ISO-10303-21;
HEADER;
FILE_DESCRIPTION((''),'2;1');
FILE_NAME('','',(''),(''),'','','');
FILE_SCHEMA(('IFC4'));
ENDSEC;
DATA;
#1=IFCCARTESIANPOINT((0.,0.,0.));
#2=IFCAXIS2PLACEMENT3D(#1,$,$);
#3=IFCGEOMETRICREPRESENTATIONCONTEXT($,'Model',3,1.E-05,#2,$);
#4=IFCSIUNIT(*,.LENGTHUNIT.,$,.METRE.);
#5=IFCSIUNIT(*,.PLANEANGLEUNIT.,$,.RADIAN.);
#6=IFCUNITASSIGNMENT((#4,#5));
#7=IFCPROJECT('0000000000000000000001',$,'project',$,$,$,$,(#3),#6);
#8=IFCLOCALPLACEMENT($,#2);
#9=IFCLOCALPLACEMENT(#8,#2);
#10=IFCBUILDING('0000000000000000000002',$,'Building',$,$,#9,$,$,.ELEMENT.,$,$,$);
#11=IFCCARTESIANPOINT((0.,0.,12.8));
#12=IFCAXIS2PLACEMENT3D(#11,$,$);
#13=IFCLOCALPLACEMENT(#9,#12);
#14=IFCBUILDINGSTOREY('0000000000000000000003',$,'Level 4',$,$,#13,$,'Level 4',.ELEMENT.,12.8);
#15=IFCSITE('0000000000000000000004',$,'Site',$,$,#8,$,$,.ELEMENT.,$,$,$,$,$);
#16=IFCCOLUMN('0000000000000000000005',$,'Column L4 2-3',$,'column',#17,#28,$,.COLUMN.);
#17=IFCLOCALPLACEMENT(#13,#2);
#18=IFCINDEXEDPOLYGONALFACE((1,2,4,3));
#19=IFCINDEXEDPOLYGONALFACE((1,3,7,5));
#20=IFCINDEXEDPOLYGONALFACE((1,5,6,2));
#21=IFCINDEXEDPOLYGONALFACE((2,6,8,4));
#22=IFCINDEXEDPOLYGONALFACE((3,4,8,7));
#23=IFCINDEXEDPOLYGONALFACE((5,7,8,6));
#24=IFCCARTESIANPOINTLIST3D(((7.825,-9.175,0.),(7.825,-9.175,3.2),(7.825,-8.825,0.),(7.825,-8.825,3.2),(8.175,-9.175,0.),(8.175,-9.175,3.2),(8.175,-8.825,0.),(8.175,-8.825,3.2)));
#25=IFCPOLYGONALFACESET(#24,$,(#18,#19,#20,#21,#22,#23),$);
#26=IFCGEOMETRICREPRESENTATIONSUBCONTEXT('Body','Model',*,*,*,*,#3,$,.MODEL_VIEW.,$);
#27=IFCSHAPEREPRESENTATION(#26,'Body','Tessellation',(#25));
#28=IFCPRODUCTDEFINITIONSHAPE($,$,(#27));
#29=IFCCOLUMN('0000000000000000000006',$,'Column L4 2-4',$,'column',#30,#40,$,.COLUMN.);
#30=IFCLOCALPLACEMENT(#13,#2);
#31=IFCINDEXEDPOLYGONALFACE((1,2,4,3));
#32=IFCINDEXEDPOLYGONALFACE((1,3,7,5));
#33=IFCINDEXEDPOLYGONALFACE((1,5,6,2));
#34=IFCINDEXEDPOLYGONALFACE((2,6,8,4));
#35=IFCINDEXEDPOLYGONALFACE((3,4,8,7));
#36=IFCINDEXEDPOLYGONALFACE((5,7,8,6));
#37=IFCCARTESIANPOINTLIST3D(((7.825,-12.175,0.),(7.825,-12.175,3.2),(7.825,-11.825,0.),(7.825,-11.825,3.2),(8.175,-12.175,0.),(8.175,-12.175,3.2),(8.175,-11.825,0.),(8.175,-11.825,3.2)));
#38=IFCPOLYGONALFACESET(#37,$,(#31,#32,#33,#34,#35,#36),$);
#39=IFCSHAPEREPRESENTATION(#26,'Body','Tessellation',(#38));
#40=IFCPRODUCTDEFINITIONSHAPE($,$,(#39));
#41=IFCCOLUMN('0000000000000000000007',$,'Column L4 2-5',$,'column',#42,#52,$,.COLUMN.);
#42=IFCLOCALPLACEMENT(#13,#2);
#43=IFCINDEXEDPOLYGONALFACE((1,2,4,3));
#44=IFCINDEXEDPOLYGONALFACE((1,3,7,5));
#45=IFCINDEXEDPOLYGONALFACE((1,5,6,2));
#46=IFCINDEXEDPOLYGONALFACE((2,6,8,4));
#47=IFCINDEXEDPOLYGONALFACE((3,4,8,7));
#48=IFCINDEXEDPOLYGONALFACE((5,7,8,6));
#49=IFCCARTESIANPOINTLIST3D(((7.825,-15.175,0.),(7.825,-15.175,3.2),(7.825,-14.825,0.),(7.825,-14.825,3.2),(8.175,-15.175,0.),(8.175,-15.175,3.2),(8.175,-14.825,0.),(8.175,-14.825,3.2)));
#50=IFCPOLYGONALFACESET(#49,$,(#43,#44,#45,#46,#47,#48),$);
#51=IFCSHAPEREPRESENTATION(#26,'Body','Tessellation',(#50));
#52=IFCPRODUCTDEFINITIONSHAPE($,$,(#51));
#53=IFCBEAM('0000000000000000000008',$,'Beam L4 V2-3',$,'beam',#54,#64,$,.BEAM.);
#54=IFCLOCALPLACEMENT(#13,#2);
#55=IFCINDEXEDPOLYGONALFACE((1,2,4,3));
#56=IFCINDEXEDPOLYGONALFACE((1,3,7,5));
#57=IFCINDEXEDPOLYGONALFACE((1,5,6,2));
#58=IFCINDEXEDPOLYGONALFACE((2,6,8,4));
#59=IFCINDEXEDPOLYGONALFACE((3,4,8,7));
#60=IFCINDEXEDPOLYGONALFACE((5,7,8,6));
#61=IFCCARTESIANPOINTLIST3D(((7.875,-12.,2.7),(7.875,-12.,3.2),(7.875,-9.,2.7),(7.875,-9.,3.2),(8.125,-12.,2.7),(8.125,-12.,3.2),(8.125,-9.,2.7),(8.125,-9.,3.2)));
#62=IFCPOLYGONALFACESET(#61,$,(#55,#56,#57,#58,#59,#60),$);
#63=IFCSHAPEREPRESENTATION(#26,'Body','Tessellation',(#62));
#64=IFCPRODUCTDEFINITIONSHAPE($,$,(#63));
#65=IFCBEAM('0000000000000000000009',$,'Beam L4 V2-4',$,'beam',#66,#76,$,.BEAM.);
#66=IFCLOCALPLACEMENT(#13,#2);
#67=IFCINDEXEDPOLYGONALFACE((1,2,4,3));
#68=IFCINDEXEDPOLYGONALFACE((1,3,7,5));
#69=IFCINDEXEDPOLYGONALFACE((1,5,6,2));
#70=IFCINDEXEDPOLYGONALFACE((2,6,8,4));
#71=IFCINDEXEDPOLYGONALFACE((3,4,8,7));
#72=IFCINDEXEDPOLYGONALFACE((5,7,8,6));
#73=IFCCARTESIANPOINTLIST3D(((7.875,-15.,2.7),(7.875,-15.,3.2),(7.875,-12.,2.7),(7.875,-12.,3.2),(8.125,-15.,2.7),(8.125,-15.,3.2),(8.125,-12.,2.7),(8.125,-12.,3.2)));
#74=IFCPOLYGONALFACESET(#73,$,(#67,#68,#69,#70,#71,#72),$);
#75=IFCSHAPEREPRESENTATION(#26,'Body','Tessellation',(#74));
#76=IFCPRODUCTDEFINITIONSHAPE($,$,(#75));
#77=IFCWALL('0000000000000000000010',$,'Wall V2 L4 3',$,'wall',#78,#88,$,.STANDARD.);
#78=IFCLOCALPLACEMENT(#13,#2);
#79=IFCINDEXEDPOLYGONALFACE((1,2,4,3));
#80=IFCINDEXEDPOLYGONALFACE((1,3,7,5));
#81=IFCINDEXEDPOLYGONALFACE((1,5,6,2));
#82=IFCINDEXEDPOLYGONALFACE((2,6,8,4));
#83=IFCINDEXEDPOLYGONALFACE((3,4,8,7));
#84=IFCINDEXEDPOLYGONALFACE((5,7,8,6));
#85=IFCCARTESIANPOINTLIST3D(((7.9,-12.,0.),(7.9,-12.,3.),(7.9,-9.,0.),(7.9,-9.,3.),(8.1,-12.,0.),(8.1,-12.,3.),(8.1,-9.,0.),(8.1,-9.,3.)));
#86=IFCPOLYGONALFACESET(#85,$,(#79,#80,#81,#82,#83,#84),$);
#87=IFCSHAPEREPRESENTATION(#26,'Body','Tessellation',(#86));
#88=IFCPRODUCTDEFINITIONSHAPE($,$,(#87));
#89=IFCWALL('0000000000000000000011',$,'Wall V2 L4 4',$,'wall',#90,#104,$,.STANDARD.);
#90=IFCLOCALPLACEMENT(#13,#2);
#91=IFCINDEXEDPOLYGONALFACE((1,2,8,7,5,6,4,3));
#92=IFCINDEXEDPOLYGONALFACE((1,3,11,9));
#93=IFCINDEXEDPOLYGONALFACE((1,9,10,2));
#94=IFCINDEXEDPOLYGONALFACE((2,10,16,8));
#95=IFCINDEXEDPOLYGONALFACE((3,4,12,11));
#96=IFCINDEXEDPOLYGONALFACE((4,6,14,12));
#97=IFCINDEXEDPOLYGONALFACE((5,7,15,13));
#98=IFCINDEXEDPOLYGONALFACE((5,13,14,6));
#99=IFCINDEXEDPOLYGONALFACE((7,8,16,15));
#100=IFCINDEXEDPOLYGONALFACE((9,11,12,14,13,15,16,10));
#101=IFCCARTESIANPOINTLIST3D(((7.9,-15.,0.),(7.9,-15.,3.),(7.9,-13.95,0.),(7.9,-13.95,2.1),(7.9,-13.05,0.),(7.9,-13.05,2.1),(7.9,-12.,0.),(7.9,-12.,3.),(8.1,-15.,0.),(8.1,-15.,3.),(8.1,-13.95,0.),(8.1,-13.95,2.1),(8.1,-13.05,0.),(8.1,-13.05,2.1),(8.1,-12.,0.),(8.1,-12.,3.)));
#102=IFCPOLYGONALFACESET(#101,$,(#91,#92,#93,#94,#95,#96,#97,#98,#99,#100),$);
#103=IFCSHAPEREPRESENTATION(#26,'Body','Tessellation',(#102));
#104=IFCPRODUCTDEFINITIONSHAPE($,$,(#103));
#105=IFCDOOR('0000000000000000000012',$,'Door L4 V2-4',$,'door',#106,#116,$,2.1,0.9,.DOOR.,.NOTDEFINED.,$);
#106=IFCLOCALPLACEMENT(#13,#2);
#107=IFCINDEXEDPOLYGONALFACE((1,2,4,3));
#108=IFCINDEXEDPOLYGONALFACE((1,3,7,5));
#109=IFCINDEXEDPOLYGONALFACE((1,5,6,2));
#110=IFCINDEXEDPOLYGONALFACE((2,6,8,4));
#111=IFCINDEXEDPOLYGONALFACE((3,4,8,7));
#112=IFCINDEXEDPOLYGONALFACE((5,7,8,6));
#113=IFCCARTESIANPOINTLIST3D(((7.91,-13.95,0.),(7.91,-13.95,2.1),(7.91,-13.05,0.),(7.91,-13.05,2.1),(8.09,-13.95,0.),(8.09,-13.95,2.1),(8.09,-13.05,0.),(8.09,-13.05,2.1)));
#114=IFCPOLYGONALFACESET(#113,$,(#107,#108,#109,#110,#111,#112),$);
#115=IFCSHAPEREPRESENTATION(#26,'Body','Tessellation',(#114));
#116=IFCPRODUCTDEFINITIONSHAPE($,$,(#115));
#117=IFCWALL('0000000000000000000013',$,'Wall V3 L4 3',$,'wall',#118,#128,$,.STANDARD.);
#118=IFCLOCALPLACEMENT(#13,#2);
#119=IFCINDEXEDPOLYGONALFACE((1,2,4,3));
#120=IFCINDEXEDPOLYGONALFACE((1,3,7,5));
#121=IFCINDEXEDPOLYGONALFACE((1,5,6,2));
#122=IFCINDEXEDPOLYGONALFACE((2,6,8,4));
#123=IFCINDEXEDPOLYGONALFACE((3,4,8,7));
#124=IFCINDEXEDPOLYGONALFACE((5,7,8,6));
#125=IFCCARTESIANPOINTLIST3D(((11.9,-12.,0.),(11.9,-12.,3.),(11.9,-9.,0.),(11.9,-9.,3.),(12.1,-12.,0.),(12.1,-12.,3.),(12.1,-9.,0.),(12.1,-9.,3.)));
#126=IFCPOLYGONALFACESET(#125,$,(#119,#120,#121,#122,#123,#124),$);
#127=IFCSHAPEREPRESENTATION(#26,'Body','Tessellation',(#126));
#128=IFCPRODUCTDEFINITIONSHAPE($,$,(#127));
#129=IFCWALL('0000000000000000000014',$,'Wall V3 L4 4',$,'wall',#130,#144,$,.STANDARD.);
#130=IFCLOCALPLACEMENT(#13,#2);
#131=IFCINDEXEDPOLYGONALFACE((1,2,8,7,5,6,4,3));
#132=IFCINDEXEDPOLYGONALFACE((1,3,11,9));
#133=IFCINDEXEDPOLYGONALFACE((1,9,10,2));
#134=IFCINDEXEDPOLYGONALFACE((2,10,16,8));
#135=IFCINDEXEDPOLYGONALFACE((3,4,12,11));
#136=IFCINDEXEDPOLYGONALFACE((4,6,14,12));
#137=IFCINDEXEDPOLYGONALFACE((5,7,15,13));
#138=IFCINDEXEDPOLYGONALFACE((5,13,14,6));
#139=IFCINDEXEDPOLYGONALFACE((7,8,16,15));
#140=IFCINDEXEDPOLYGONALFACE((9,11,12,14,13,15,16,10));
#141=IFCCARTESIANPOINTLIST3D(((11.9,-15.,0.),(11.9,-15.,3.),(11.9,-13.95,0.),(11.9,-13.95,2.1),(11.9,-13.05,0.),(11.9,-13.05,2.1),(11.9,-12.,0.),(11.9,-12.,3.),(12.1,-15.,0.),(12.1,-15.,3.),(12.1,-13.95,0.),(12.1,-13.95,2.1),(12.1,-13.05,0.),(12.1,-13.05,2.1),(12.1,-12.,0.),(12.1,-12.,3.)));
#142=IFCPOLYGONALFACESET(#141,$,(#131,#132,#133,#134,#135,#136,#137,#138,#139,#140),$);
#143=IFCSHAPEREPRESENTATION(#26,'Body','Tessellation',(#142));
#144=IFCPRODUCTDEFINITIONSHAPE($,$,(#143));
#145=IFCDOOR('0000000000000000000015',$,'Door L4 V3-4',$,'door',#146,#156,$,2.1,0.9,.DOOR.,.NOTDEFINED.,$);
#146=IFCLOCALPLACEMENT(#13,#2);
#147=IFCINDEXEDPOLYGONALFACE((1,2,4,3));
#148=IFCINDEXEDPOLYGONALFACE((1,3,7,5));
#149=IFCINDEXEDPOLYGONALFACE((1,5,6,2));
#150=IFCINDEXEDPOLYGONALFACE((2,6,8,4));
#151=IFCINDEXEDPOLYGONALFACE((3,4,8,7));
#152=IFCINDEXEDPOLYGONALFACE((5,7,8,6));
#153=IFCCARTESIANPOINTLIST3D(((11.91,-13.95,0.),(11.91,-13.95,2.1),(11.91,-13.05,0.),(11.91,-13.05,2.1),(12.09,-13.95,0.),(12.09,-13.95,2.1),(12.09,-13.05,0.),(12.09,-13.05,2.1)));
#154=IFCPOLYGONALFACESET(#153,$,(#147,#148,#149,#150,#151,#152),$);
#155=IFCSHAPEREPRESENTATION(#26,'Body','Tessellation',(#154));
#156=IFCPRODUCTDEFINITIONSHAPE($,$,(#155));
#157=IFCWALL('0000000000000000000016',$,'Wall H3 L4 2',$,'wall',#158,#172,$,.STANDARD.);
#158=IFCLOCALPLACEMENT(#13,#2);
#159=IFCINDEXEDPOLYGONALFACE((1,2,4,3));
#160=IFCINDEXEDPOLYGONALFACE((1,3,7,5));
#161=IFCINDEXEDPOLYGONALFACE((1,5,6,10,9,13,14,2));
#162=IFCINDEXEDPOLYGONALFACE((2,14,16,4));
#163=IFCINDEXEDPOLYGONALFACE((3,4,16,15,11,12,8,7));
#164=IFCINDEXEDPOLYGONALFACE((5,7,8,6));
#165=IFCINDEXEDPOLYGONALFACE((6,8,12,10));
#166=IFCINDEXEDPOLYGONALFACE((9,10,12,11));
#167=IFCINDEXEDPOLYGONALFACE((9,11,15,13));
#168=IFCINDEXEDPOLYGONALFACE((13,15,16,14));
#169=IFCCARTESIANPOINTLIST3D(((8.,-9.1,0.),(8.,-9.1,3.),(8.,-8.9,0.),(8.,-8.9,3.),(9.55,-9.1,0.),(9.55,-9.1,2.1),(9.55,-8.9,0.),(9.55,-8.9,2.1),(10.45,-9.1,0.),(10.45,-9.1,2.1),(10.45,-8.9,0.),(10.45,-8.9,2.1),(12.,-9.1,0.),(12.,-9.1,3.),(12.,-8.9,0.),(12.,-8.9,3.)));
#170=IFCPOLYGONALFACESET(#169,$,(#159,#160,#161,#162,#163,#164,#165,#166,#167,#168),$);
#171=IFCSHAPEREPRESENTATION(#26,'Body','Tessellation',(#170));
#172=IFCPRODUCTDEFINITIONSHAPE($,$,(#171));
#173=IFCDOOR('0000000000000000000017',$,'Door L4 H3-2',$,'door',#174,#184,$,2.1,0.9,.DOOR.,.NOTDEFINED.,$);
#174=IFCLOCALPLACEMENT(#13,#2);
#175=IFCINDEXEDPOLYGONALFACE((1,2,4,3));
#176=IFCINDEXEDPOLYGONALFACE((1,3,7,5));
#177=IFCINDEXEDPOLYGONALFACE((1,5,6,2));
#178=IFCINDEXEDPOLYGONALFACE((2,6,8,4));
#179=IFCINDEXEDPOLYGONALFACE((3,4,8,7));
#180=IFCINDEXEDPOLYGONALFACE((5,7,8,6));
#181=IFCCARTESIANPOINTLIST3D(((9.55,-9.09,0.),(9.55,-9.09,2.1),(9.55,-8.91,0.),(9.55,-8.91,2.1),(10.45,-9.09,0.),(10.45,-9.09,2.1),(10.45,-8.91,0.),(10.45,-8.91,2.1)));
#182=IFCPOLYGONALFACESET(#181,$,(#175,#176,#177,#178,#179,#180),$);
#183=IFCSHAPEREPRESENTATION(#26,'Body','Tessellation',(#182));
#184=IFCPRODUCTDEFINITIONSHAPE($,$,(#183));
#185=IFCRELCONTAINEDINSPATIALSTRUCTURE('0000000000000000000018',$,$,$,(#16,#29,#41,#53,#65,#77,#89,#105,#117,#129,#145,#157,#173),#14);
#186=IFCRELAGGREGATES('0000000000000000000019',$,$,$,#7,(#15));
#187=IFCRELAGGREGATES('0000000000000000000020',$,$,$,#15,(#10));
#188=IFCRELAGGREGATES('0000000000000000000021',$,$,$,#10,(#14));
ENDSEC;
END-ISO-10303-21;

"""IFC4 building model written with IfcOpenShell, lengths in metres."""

from ifc_helpers import new_model, si_unit, frame, frame_2d, origin, origin_2d, place, context, subcontext, project, spatial, rectangle, extrude, element, fill, save


model = new_model("IFC4")

# Units and contexts
model_context = context("Model", 3, precision=1e-05, world=origin())
body_context = subcontext(model_context, "Body", "Model", "MODEL_VIEW")
ifc_project = project(units=[si_unit("LENGTHUNIT", "METRE"), si_unit("PLANEANGLEUNIT", "RADIAN")], contexts=[model_context])

# Site, building, storey
site_placement = place(None, origin())
site = spatial("IfcSite", under=ifc_project, at=site_placement, Name="Site", CompositionType="ELEMENT")
building_placement = place(site_placement, origin())
building = spatial("IfcBuilding", under=site, at=building_placement, Name="Building", CompositionType="ELEMENT")
storey_placement = place(building_placement, frame((0.0, 0.0, 12.8)))
storey = spatial("IfcBuildingStorey", under=building, at=storey_placement, Name="Level 4", LongName="Level 4", CompositionType="ELEMENT", Elevation=12.8)

# Columns
for number, where, name in (
    (1, (8.0, -9.0, 0.0), "Column L4 2-3"),
    (2, (8.0, -12.0, 0.0), "Column L4 2-4"),
    (3, (8.0, -15.0, 0.0), "Column L4 2-5"),
):
    element("IfcColumn", number, at=place(storey_placement, frame(where)), inside=storey, Name=name, ObjectType="column", PredefinedType="COLUMN", context=body_context, shape_type="SweptSolid", body=[
        extrude(rectangle(XDim=0.35, YDim=0.35, at=origin_2d()), origin(), (0.0, 0.0, 1.0), 3.2),
    ])

# Beams
for number, where, z_axis, x_axis, name in (
    (4, (8.0, -9.0, 2.95), (0.0, -1.0, 0.0), (0.0, 0.0, 1.0), "Beam L4 V2-3"),
    (5, (8.0, -12.0, 2.95), (0.0, -1.0, 0.0), (0.0, 0.0, 1.0), "Beam L4 V2-4"),
):
    element("IfcBeam", number, at=place(storey_placement, frame(where, z_axis=z_axis, x_axis=x_axis)), inside=storey, Name=name, ObjectType="beam", PredefinedType="BEAM", context=body_context, shape_type="SweptSolid", body=[
        extrude(rectangle(XDim=0.5, YDim=0.25, at=origin_2d()), origin(), (0.0, 0.0, 1.0), 3.0),
    ])

# Wall
wall_1_placement = place(storey_placement, frame((8.0, -9.0, 0.0), z_axis=(0.0, 0.0, 1.0), x_axis=(0.0, -1.0, 0.0)))
element("IfcWall", 6, at=wall_1_placement, inside=storey, Name="Wall V2 L4 3", ObjectType="wall", PredefinedType="STANDARD", context=body_context, shape_type="SweptSolid", body=[
    extrude(rectangle(XDim=3.0, YDim=0.2, at=frame_2d((1.5, 0.0))), origin(), (0.0, 0.0, 1.0), 3.0),
])

# Wall, opening, door
wall_2_placement = place(storey_placement, frame((8.0, -12.0, 0.0), z_axis=(0.0, 0.0, 1.0), x_axis=(0.0, -1.0, 0.0)))
wall_2 = element("IfcWall", 7, at=wall_2_placement, inside=storey, Name="Wall V2 L4 4", ObjectType="wall", PredefinedType="STANDARD", context=body_context, shape_type="SweptSolid", body=[
    extrude(rectangle(XDim=3.0, YDim=0.2, at=frame_2d((1.5, 0.0))), origin(), (0.0, 0.0, 1.0), 3.0),
])
opening_1_placement = place(storey_placement, frame((8.0, -13.5, 0.0), z_axis=(0.0, 0.0, 1.0), x_axis=(0.0, -1.0, 0.0)))
opening_1 = element("IfcOpeningElement", 8, at=opening_1_placement, cuts=wall_2, ObjectType="Opening", PredefinedType="OPENING", context=body_context, shape_type="SweptSolid", body=[
    extrude(rectangle(XDim=0.9, YDim=0.22, at=origin_2d()), origin(), (0.0, 0.0, 1.0), 2.1),
])
door_1_placement = place(storey_placement, frame((8.0, -13.5, 0.0), z_axis=(0.0, 0.0, 1.0), x_axis=(0.0, -1.0, 0.0)))
door_1 = element("IfcDoor", 9, at=door_1_placement, inside=storey, Name="Door L4 V2-4", ObjectType="door", OperationType="NOTDEFINED", OverallHeight=2.1, OverallWidth=0.9, PredefinedType="DOOR", context=body_context, shape_type="SweptSolid", body=[
    extrude(rectangle(XDim=0.9, YDim=0.18, at=origin_2d()), origin(), (0.0, 0.0, 1.0), 2.1),
])
fill(opening_1, door_1)

# Wall
wall_3_placement = place(storey_placement, frame((12.0, -9.0, 0.0), z_axis=(0.0, 0.0, 1.0), x_axis=(0.0, -1.0, 0.0)))
element("IfcWall", 10, at=wall_3_placement, inside=storey, Name="Wall V3 L4 3", ObjectType="wall", PredefinedType="STANDARD", context=body_context, shape_type="SweptSolid", body=[
    extrude(rectangle(XDim=3.0, YDim=0.2, at=frame_2d((1.5, 0.0))), origin(), (0.0, 0.0, 1.0), 3.0),
])

# Walls, openings, doors
wall_4_placement = place(storey_placement, frame((12.0, -12.0, 0.0), z_axis=(0.0, 0.0, 1.0), x_axis=(0.0, -1.0, 0.0)))
wall_4 = element("IfcWall", 11, at=wall_4_placement, inside=storey, Name="Wall V3 L4 4", ObjectType="wall", PredefinedType="STANDARD", context=body_context, shape_type="SweptSolid", body=[
    extrude(rectangle(XDim=3.0, YDim=0.2, at=frame_2d((1.5, 0.0))), origin(), (0.0, 0.0, 1.0), 3.0),
])
opening_2_placement = place(storey_placement, frame((12.0, -13.5, 0.0), z_axis=(0.0, 0.0, 1.0), x_axis=(0.0, -1.0, 0.0)))
opening_2 = element("IfcOpeningElement", 12, at=opening_2_placement, cuts=wall_4, ObjectType="Opening", PredefinedType="OPENING", context=body_context, shape_type="SweptSolid", body=[
    extrude(rectangle(XDim=0.9, YDim=0.22, at=origin_2d()), origin(), (0.0, 0.0, 1.0), 2.1),
])
door_2_placement = place(storey_placement, frame((12.0, -13.5, 0.0), z_axis=(0.0, 0.0, 1.0), x_axis=(0.0, -1.0, 0.0)))
door_2 = element("IfcDoor", 13, at=door_2_placement, inside=storey, Name="Door L4 V3-4", ObjectType="door", OperationType="NOTDEFINED", OverallHeight=2.1, OverallWidth=0.9, PredefinedType="DOOR", context=body_context, shape_type="SweptSolid", body=[
    extrude(rectangle(XDim=0.9, YDim=0.18, at=origin_2d()), origin(), (0.0, 0.0, 1.0), 2.1),
])
fill(opening_2, door_2)
wall_5_placement = place(storey_placement, frame((8.0, -9.0, 0.0), z_axis=(0.0, 0.0, 1.0), x_axis=(1.0, 0.0, 0.0)))
wall_5 = element("IfcWall", 14, at=wall_5_placement, inside=storey, Name="Wall H3 L4 2", ObjectType="wall", PredefinedType="STANDARD", context=body_context, shape_type="SweptSolid", body=[
    extrude(rectangle(XDim=4.0, YDim=0.2, at=frame_2d((2.0, 0.0))), origin(), (0.0, 0.0, 1.0), 3.0),
])
opening_3_placement = place(storey_placement, frame((10.0, -9.0, 0.0), z_axis=(0.0, 0.0, 1.0), x_axis=(1.0, 0.0, 0.0)))
opening_3 = element("IfcOpeningElement", 15, at=opening_3_placement, cuts=wall_5, ObjectType="Opening", PredefinedType="OPENING", context=body_context, shape_type="SweptSolid", body=[
    extrude(rectangle(XDim=0.9, YDim=0.22, at=origin_2d()), origin(), (0.0, 0.0, 1.0), 2.1),
])
door_3_placement = place(storey_placement, frame((10.0, -9.0, 0.0), z_axis=(0.0, 0.0, 1.0), x_axis=(1.0, 0.0, 0.0)))
door_3 = element("IfcDoor", 16, at=door_3_placement, inside=storey, Name="Door L4 H3-2", ObjectType="door", OperationType="NOTDEFINED", OverallHeight=2.1, OverallWidth=0.9, PredefinedType="DOOR", context=body_context, shape_type="SweptSolid", body=[
    extrude(rectangle(XDim=0.9, YDim=0.18, at=origin_2d()), origin(), (0.0, 0.0, 1.0), 2.1),
])
fill(opening_3, door_3)

save(model, "model.ifc")
